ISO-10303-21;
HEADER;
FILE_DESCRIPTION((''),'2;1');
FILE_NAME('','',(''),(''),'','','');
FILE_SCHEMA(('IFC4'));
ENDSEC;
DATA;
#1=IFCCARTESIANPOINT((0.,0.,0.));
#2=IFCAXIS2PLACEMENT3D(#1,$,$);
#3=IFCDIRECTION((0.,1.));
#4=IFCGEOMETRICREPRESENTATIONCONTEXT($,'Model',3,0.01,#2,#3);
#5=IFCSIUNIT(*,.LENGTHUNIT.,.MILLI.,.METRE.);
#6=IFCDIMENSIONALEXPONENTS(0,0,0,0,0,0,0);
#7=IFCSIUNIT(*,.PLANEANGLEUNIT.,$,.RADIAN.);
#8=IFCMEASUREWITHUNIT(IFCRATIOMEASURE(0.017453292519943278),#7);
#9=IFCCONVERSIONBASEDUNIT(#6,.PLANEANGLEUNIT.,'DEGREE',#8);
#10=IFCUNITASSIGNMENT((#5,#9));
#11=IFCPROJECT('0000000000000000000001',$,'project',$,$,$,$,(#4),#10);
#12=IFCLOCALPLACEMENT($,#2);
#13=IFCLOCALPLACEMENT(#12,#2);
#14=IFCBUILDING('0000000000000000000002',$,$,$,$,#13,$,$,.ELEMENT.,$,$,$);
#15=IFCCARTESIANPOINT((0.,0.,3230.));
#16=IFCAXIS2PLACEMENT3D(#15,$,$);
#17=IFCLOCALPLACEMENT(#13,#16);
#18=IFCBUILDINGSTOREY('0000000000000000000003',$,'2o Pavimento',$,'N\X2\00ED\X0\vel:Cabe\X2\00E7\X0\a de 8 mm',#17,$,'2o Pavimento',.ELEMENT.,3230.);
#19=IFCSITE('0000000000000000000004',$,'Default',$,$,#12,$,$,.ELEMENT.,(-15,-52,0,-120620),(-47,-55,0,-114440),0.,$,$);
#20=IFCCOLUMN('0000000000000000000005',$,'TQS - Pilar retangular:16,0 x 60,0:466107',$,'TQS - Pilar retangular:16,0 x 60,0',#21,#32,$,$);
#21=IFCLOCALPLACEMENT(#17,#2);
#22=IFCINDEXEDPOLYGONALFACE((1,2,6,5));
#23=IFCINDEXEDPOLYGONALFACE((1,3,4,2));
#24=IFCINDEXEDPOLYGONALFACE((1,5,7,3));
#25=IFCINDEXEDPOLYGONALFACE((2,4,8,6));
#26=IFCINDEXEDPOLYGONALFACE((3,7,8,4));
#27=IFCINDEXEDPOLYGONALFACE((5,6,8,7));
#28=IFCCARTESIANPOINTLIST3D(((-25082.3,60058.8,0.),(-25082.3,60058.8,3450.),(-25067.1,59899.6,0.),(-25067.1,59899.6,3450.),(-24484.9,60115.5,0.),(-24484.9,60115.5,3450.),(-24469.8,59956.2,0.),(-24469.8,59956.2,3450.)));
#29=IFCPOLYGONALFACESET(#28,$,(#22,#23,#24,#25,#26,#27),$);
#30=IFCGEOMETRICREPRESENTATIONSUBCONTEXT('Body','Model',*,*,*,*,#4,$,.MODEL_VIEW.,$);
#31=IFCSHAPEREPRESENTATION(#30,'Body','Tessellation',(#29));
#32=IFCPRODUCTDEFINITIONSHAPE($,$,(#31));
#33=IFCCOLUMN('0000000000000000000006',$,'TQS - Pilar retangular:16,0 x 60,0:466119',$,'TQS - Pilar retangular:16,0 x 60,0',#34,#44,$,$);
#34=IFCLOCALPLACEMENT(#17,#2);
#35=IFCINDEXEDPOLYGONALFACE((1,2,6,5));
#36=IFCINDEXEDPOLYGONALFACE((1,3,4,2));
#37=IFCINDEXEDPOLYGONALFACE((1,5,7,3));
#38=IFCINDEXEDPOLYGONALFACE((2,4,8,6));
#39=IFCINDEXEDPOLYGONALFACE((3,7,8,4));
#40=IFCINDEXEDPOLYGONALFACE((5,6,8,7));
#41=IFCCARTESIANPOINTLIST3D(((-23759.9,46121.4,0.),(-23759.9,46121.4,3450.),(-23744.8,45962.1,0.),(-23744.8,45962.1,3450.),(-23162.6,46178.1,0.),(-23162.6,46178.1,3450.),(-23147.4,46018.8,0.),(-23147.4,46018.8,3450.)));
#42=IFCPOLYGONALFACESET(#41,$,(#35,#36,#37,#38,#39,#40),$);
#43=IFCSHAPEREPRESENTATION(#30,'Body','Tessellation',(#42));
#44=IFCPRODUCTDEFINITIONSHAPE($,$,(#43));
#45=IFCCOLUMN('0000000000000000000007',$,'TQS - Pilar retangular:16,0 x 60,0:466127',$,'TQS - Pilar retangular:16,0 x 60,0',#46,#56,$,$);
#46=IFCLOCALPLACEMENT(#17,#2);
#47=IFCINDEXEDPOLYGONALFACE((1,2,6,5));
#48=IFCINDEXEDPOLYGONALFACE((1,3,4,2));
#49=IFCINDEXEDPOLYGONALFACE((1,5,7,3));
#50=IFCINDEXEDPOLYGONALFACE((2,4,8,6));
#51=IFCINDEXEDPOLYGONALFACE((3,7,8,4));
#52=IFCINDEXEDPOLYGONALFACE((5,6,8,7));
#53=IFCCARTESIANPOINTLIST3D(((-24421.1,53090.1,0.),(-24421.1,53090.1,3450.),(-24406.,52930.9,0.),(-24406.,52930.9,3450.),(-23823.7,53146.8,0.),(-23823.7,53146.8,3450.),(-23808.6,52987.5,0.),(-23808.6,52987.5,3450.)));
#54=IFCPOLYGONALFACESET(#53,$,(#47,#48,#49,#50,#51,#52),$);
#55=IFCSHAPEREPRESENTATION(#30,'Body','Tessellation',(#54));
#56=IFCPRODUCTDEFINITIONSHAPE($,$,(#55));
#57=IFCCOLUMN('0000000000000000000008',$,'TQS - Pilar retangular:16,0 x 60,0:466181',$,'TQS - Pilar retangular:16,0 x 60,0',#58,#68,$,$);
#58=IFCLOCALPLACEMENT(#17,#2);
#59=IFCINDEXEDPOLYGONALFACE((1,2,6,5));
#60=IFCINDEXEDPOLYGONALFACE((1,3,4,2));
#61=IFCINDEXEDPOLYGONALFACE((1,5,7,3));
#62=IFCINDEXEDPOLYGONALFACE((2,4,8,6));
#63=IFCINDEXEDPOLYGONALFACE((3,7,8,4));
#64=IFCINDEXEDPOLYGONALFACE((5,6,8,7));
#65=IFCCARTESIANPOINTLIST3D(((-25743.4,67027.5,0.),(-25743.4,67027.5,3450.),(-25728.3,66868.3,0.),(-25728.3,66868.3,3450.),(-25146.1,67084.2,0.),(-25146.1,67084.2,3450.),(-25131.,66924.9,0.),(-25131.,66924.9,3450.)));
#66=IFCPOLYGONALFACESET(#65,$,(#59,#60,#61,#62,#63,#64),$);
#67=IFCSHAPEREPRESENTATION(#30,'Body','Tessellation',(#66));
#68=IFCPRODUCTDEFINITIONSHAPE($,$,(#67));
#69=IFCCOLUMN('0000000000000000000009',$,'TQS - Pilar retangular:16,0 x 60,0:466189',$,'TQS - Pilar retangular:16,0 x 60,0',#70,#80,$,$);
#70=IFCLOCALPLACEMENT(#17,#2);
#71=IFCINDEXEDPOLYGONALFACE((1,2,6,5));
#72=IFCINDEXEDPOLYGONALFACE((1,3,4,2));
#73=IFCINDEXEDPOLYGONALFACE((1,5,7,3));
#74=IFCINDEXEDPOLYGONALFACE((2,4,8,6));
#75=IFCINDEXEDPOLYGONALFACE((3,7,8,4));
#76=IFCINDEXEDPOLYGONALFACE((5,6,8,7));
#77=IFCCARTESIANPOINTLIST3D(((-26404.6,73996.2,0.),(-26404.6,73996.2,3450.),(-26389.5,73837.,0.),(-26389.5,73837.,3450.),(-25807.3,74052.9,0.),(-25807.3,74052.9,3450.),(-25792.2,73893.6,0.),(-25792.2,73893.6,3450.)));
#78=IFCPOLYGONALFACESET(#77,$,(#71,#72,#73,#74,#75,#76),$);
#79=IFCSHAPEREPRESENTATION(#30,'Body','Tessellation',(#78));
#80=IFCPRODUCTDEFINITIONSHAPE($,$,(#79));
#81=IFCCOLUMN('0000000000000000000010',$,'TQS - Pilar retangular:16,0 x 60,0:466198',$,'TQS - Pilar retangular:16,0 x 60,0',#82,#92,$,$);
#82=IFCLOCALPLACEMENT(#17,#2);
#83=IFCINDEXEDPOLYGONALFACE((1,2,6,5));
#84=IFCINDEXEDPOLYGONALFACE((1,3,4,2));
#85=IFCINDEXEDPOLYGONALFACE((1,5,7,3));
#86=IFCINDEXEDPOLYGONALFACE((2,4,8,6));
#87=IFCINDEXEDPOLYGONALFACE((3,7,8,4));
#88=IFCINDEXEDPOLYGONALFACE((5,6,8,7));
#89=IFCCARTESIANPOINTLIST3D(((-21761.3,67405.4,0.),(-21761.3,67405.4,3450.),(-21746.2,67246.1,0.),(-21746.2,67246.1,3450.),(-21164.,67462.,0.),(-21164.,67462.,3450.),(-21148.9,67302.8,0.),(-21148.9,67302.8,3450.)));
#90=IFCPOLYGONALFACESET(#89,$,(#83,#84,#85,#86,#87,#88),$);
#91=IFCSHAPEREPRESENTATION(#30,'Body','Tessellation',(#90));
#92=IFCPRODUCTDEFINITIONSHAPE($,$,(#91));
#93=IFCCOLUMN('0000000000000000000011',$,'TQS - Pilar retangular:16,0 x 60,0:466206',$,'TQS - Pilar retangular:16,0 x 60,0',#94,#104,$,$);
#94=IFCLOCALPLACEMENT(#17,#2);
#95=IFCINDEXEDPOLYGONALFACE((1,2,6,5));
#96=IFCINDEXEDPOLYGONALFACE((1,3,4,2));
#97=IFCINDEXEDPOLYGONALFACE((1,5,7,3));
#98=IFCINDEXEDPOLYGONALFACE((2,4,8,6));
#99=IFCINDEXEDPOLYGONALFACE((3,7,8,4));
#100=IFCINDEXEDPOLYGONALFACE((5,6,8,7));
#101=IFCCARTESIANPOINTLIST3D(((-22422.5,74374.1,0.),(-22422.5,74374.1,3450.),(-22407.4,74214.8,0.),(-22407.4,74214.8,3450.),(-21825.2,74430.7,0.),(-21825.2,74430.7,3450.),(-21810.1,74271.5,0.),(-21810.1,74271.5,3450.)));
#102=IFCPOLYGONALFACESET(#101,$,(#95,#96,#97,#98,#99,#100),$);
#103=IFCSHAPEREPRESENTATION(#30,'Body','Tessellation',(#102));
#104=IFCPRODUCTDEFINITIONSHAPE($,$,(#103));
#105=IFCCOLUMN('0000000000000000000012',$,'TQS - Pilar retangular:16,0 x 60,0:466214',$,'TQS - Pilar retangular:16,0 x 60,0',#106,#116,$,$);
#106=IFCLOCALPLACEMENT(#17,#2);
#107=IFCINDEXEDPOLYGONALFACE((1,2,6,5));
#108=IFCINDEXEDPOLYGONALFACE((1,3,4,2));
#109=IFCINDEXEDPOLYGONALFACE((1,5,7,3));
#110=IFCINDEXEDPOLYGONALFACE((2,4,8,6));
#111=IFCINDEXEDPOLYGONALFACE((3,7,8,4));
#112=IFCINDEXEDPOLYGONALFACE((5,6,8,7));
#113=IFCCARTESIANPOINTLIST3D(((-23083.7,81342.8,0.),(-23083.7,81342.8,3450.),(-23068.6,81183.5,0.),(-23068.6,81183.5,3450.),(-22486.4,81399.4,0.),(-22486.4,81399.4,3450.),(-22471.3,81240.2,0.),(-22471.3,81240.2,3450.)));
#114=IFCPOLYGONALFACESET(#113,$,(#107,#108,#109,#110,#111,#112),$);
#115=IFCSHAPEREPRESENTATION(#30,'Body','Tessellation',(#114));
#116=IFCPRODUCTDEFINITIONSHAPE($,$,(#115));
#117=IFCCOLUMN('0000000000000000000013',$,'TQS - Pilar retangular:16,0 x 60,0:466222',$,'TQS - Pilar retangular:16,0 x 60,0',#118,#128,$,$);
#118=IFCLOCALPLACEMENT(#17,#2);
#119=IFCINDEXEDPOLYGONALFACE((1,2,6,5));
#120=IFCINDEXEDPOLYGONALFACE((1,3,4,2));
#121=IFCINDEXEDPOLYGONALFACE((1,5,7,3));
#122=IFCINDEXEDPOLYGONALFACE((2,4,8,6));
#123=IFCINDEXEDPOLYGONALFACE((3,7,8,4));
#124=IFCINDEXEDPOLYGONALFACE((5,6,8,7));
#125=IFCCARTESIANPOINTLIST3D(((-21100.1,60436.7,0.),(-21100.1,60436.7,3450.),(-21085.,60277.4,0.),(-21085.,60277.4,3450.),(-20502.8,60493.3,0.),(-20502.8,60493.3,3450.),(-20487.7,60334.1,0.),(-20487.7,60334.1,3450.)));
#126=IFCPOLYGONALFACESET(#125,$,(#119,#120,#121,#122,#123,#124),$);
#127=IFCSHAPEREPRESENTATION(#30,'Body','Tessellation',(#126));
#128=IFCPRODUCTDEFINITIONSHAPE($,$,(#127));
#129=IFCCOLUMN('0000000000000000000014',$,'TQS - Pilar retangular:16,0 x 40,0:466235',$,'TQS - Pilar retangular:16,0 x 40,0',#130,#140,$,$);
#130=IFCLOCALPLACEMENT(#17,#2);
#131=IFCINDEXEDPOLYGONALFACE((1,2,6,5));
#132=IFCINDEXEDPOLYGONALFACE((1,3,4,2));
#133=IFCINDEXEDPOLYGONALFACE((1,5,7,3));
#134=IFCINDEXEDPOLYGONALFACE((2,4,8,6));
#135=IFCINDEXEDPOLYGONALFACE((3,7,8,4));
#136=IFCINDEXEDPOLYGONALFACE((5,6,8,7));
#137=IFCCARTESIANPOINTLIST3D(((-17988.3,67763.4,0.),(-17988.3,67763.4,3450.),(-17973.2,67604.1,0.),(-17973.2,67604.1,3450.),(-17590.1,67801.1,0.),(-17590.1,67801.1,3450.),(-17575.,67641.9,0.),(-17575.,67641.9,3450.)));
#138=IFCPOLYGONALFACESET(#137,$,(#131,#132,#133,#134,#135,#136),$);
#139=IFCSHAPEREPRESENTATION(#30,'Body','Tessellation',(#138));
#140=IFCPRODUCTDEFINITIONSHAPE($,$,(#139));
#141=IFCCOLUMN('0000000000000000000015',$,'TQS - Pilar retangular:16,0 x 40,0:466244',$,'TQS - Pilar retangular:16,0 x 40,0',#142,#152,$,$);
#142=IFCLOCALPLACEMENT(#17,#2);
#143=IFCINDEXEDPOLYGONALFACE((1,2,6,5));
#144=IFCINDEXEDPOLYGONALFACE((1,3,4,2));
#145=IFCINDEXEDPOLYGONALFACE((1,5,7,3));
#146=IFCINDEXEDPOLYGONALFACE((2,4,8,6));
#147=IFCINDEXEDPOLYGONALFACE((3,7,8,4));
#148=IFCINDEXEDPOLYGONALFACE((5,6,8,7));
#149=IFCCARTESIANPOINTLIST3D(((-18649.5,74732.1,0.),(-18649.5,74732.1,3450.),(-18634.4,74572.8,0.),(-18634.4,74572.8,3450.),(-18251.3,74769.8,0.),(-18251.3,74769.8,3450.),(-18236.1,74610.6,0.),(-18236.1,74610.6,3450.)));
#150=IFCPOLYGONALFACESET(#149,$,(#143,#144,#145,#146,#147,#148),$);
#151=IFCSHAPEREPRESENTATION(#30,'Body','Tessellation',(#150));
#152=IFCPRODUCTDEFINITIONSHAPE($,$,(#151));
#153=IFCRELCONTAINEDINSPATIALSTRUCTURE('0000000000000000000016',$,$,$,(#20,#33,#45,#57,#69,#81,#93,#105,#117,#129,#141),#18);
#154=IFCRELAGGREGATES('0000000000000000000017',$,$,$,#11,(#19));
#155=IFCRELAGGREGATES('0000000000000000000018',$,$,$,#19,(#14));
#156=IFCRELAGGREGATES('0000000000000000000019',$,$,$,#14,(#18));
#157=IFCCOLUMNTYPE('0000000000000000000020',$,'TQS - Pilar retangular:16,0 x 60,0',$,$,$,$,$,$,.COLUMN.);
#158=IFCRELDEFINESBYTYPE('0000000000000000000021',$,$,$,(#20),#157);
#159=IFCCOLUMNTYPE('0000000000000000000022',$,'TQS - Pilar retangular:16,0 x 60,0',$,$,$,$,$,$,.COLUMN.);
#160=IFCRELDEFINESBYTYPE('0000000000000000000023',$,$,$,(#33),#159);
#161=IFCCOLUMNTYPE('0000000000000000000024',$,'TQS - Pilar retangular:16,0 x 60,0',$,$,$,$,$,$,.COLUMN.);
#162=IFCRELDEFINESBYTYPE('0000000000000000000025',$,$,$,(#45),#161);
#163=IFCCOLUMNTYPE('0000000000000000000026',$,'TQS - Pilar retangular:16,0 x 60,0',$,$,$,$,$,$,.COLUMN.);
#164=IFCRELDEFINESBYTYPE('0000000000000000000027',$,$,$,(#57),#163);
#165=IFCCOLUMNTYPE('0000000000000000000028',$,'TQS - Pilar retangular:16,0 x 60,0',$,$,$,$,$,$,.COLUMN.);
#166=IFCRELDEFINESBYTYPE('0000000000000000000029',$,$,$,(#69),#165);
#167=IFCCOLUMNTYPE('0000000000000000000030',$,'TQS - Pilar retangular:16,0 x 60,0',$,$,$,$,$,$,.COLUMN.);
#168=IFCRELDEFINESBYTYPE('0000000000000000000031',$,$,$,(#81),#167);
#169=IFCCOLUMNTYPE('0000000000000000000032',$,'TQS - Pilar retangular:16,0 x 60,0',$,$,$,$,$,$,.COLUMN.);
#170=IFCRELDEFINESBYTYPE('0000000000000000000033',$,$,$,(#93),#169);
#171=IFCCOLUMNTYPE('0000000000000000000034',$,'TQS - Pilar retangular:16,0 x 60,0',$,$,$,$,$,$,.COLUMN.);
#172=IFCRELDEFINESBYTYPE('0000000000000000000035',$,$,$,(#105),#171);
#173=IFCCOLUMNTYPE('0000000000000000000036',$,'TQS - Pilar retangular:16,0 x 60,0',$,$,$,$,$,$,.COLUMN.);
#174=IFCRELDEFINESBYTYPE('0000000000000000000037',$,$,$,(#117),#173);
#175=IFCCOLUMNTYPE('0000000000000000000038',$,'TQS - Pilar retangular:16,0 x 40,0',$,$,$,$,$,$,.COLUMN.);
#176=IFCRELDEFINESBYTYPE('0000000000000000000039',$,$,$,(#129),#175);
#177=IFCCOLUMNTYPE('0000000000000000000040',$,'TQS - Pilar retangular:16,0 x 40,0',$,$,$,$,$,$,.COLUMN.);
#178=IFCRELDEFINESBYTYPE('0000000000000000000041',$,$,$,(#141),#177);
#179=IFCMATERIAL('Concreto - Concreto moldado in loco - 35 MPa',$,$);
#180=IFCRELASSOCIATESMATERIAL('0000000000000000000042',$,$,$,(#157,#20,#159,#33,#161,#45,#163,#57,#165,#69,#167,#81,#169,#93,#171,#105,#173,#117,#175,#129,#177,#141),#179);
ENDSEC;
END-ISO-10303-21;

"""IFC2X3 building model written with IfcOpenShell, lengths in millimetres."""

from ifc_helpers import new_model, entity, si_unit, converted_unit, direction, frame, origin, origin_2d_with_axis, place, context, subcontext, project, spatial, rectangle, extrude, source, transform, mapped, material, type_object, type_shapes, element, save


model = new_model("IFC2X3")

# Units and contexts
model_context = context("Model", 3, precision=0.01, world=origin(), true_north=direction((0.0, 1.0)))
body_context = subcontext(model_context, "Body", "Model", "MODEL_VIEW")
ifc_project = project(units=[si_unit("LENGTHUNIT", "METRE", prefix="MILLI"), converted_unit("PLANEANGLEUNIT", "DEGREE", entity("IfcRatioMeasure", 0.017453292519943278), si_unit("PLANEANGLEUNIT", "RADIAN"), dimensions=[0, 0, 0, 0, 0, 0, 0])], contexts=[model_context])

# Site, building, storey
site_placement = place(None, origin())
site = spatial("IfcSite", under=ifc_project, at=site_placement, Name="Default", CompositionType="ELEMENT", RefLatitude=(-15, -52, 0, -120620), RefLongitude=(-47, -55, 0, -114440), RefElevation=0.0)
building_placement = place(site_placement, origin())
building = spatial("IfcBuilding", under=site, at=building_placement, CompositionType="ELEMENT")
storey_placement = place(building_placement, frame((0.0, 0.0, 3230.0)))
storey = spatial("IfcBuildingStorey", under=building, at=storey_placement, Name="2o Pavimento", ObjectType="Nível:Cabeça de 8 mm", LongName="2o Pavimento", CompositionType="ELEMENT", Elevation=3230.0)

# Columns
ifc_material = material(Name="Concreto - Concreto moldado in loco - 35 MPa")
column_type_1 = type_object("IfcColumnType", Name="TQS - Pilar retangular:16,0 x 60,0", PredefinedType="COLUMN", material=ifc_material)
shared_shape_1 = source(origin(), body_context, "Body", "SweptSolid", [
    extrude(rectangle(XDim=600.0, YDim=160.0, at=origin_2d_with_axis()), frame((-24776.0, 60007.5, 3230.0), z_axis=(0.0, 0.0, 1.0), x_axis=(-0.995529, -0.094456, 0.0)), (0.0, 0.0, 1.0), 3450.0),
])
type_shapes(column_type_1, [shared_shape_1])
column_1_placement = place(storey_placement, frame((0.0, 0.0, -3230.0)))
element("IfcColumn", 1, at=column_1_placement, inside=storey, type_object=column_type_1, material=ifc_material, Name="TQS - Pilar retangular:16,0 x 60,0:466107", ObjectType="TQS - Pilar retangular:16,0 x 60,0", context=body_context, shape_type="MappedRepresentation", body=[
    mapped(shared_shape_1, transform((0.0, 0.0, 0.0), scale=1.0)),
])
column_type_2 = type_object("IfcColumnType", Name="TQS - Pilar retangular:16,0 x 60,0", PredefinedType="COLUMN", material=ifc_material)
shared_shape_2 = source(origin(), body_context, "Body", "SweptSolid", [
    extrude(rectangle(XDim=600.0, YDim=160.0, at=origin_2d_with_axis()), frame((-23453.7, 46070.1, 3230.0), z_axis=(0.0, 0.0, 1.0), x_axis=(-0.995529, -0.094456, 0.0)), (0.0, 0.0, 1.0), 3450.0),
])
type_shapes(column_type_2, [shared_shape_2])
column_2_placement = place(storey_placement, frame((0.0, 0.0, -3230.0)))
element("IfcColumn", 2, at=column_2_placement, inside=storey, type_object=column_type_2, material=ifc_material, Name="TQS - Pilar retangular:16,0 x 60,0:466119", ObjectType="TQS - Pilar retangular:16,0 x 60,0", context=body_context, shape_type="MappedRepresentation", body=[
    mapped(shared_shape_2, transform((0.0, 0.0, 0.0), scale=1.0)),
])
column_type_3 = type_object("IfcColumnType", Name="TQS - Pilar retangular:16,0 x 60,0", PredefinedType="COLUMN", material=ifc_material)
shared_shape_3 = source(origin(), body_context, "Body", "SweptSolid", [
    extrude(rectangle(XDim=600.0, YDim=160.0, at=origin_2d_with_axis()), frame((-24114.9, 53038.8, 3230.0), z_axis=(0.0, 0.0, 1.0), x_axis=(-0.995529, -0.094456, 0.0)), (0.0, 0.0, 1.0), 3450.0),
])
type_shapes(column_type_3, [shared_shape_3])
column_3_placement = place(storey_placement, frame((0.0, 0.0, -3230.0)))
element("IfcColumn", 3, at=column_3_placement, inside=storey, type_object=column_type_3, material=ifc_material, Name="TQS - Pilar retangular:16,0 x 60,0:466127", ObjectType="TQS - Pilar retangular:16,0 x 60,0", context=body_context, shape_type="MappedRepresentation", body=[
    mapped(shared_shape_3, transform((0.0, 0.0, 0.0), scale=1.0)),
])
column_type_4 = type_object("IfcColumnType", Name="TQS - Pilar retangular:16,0 x 60,0", PredefinedType="COLUMN", material=ifc_material)
shared_shape_4 = source(origin(), body_context, "Body", "SweptSolid", [
    extrude(rectangle(XDim=600.0, YDim=160.0, at=origin_2d_with_axis()), frame((-25437.2, 66976.2, 3230.0), z_axis=(0.0, 0.0, 1.0), x_axis=(-0.995529, -0.094456, 0.0)), (0.0, 0.0, 1.0), 3450.0),
])
type_shapes(column_type_4, [shared_shape_4])
column_4_placement = place(storey_placement, frame((0.0, 0.0, -3230.0)))
element("IfcColumn", 4, at=column_4_placement, inside=storey, type_object=column_type_4, material=ifc_material, Name="TQS - Pilar retangular:16,0 x 60,0:466181", ObjectType="TQS - Pilar retangular:16,0 x 60,0", context=body_context, shape_type="MappedRepresentation", body=[
    mapped(shared_shape_4, transform((0.0, 0.0, 0.0), scale=1.0)),
])
column_type_5 = type_object("IfcColumnType", Name="TQS - Pilar retangular:16,0 x 60,0", PredefinedType="COLUMN", material=ifc_material)
shared_shape_5 = source(origin(), body_context, "Body", "SweptSolid", [
    extrude(rectangle(XDim=600.0, YDim=160.0, at=origin_2d_with_axis()), frame((-26098.4, 73944.9, 3230.0), z_axis=(0.0, 0.0, 1.0), x_axis=(-0.995529, -0.094456, 0.0)), (0.0, 0.0, 1.0), 3450.0),
])
type_shapes(column_type_5, [shared_shape_5])
column_5_placement = place(storey_placement, frame((0.0, 0.0, -3230.0)))
element("IfcColumn", 5, at=column_5_placement, inside=storey, type_object=column_type_5, material=ifc_material, Name="TQS - Pilar retangular:16,0 x 60,0:466189", ObjectType="TQS - Pilar retangular:16,0 x 60,0", context=body_context, shape_type="MappedRepresentation", body=[
    mapped(shared_shape_5, transform((0.0, 0.0, 0.0), scale=1.0)),
])
column_type_6 = type_object("IfcColumnType", Name="TQS - Pilar retangular:16,0 x 60,0", PredefinedType="COLUMN", material=ifc_material)
shared_shape_6 = source(origin(), body_context, "Body", "SweptSolid", [
    extrude(rectangle(XDim=600.0, YDim=160.0, at=origin_2d_with_axis()), frame((-21455.1, 67354.1, 3230.0), z_axis=(0.0, 0.0, 1.0), x_axis=(-0.995529, -0.094456, 0.0)), (0.0, 0.0, 1.0), 3450.0),
])
type_shapes(column_type_6, [shared_shape_6])
column_6_placement = place(storey_placement, frame((0.0, 0.0, -3230.0)))
element("IfcColumn", 6, at=column_6_placement, inside=storey, type_object=column_type_6, material=ifc_material, Name="TQS - Pilar retangular:16,0 x 60,0:466198", ObjectType="TQS - Pilar retangular:16,0 x 60,0", context=body_context, shape_type="MappedRepresentation", body=[
    mapped(shared_shape_6, transform((0.0, 0.0, 0.0), scale=1.0)),
])
column_type_7 = type_object("IfcColumnType", Name="TQS - Pilar retangular:16,0 x 60,0", PredefinedType="COLUMN", material=ifc_material)
shared_shape_7 = source(origin(), body_context, "Body", "SweptSolid", [
    extrude(rectangle(XDim=600.0, YDim=160.0, at=origin_2d_with_axis()), frame((-22116.3, 74322.8, 3230.0), z_axis=(0.0, 0.0, 1.0), x_axis=(-0.995529, -0.094456, 0.0)), (0.0, 0.0, 1.0), 3450.0),
])
type_shapes(column_type_7, [shared_shape_7])
column_7_placement = place(storey_placement, frame((0.0, 0.0, -3230.0)))
element("IfcColumn", 7, at=column_7_placement, inside=storey, type_object=column_type_7, material=ifc_material, Name="TQS - Pilar retangular:16,0 x 60,0:466206", ObjectType="TQS - Pilar retangular:16,0 x 60,0", context=body_context, shape_type="MappedRepresentation", body=[
    mapped(shared_shape_7, transform((0.0, 0.0, 0.0), scale=1.0)),
])
column_type_8 = type_object("IfcColumnType", Name="TQS - Pilar retangular:16,0 x 60,0", PredefinedType="COLUMN", material=ifc_material)
shared_shape_8 = source(origin(), body_context, "Body", "SweptSolid", [
    extrude(rectangle(XDim=600.0, YDim=160.0, at=origin_2d_with_axis()), frame((-22777.5, 81291.5, 3230.0), z_axis=(0.0, 0.0, 1.0), x_axis=(-0.995529, -0.094456, 0.0)), (0.0, 0.0, 1.0), 3450.0),
])
type_shapes(column_type_8, [shared_shape_8])
column_8_placement = place(storey_placement, frame((0.0, 0.0, -3230.0)))
element("IfcColumn", 8, at=column_8_placement, inside=storey, type_object=column_type_8, material=ifc_material, Name="TQS - Pilar retangular:16,0 x 60,0:466214", ObjectType="TQS - Pilar retangular:16,0 x 60,0", context=body_context, shape_type="MappedRepresentation", body=[
    mapped(shared_shape_8, transform((0.0, 0.0, 0.0), scale=1.0)),
])
column_type_9 = type_object("IfcColumnType", Name="TQS - Pilar retangular:16,0 x 60,0", PredefinedType="COLUMN", material=ifc_material)
shared_shape_9 = source(origin(), body_context, "Body", "SweptSolid", [
    extrude(rectangle(XDim=600.0, YDim=160.0, at=origin_2d_with_axis()), frame((-20793.9, 60385.4, 3230.0), z_axis=(0.0, 0.0, 1.0), x_axis=(-0.995529, -0.094456, 0.0)), (0.0, 0.0, 1.0), 3450.0),
])
type_shapes(column_type_9, [shared_shape_9])
column_9_placement = place(storey_placement, frame((0.0, 0.0, -3230.0)))
element("IfcColumn", 9, at=column_9_placement, inside=storey, type_object=column_type_9, material=ifc_material, Name="TQS - Pilar retangular:16,0 x 60,0:466222", ObjectType="TQS - Pilar retangular:16,0 x 60,0", context=body_context, shape_type="MappedRepresentation", body=[
    mapped(shared_shape_9, transform((0.0, 0.0, 0.0), scale=1.0)),
])
column_type_10 = type_object("IfcColumnType", Name="TQS - Pilar retangular:16,0 x 40,0", PredefinedType="COLUMN", material=ifc_material)
shared_shape_10 = source(origin(), body_context, "Body", "SweptSolid", [
    extrude(rectangle(XDim=400.0, YDim=160.0, at=origin_2d_with_axis()), frame((-17781.6, 67702.6, 3230.0), z_axis=(0.0, 0.0, 1.0), x_axis=(-0.995529, -0.094456, 0.0)), (0.0, 0.0, 1.0), 3450.0),
])
type_shapes(column_type_10, [shared_shape_10])
column_10_placement = place(storey_placement, frame((0.0, 0.0, -3230.0)))
element("IfcColumn", 10, at=column_10_placement, inside=storey, type_object=column_type_10, material=ifc_material, Name="TQS - Pilar retangular:16,0 x 40,0:466235", ObjectType="TQS - Pilar retangular:16,0 x 40,0", context=body_context, shape_type="MappedRepresentation", body=[
    mapped(shared_shape_10, transform((0.0, 0.0, 0.0), scale=1.0)),
])
column_type_11 = type_object("IfcColumnType", Name="TQS - Pilar retangular:16,0 x 40,0", PredefinedType="COLUMN", material=ifc_material)
shared_shape_11 = source(origin(), body_context, "Body", "SweptSolid", [
    extrude(rectangle(XDim=400.0, YDim=160.0, at=origin_2d_with_axis()), frame((-18442.8, 74671.3, 3230.0), z_axis=(0.0, 0.0, 1.0), x_axis=(-0.995529, -0.094456, 0.0)), (0.0, 0.0, 1.0), 3450.0),
])
type_shapes(column_type_11, [shared_shape_11])
column_11_placement = place(storey_placement, frame((0.0, 0.0, -3230.0)))
element("IfcColumn", 11, at=column_11_placement, inside=storey, type_object=column_type_11, material=ifc_material, Name="TQS - Pilar retangular:16,0 x 40,0:466244", ObjectType="TQS - Pilar retangular:16,0 x 40,0", context=body_context, shape_type="MappedRepresentation", body=[
    mapped(shared_shape_11, transform((0.0, 0.0, 0.0), scale=1.0)),
])

save(model, "model.ifc")
